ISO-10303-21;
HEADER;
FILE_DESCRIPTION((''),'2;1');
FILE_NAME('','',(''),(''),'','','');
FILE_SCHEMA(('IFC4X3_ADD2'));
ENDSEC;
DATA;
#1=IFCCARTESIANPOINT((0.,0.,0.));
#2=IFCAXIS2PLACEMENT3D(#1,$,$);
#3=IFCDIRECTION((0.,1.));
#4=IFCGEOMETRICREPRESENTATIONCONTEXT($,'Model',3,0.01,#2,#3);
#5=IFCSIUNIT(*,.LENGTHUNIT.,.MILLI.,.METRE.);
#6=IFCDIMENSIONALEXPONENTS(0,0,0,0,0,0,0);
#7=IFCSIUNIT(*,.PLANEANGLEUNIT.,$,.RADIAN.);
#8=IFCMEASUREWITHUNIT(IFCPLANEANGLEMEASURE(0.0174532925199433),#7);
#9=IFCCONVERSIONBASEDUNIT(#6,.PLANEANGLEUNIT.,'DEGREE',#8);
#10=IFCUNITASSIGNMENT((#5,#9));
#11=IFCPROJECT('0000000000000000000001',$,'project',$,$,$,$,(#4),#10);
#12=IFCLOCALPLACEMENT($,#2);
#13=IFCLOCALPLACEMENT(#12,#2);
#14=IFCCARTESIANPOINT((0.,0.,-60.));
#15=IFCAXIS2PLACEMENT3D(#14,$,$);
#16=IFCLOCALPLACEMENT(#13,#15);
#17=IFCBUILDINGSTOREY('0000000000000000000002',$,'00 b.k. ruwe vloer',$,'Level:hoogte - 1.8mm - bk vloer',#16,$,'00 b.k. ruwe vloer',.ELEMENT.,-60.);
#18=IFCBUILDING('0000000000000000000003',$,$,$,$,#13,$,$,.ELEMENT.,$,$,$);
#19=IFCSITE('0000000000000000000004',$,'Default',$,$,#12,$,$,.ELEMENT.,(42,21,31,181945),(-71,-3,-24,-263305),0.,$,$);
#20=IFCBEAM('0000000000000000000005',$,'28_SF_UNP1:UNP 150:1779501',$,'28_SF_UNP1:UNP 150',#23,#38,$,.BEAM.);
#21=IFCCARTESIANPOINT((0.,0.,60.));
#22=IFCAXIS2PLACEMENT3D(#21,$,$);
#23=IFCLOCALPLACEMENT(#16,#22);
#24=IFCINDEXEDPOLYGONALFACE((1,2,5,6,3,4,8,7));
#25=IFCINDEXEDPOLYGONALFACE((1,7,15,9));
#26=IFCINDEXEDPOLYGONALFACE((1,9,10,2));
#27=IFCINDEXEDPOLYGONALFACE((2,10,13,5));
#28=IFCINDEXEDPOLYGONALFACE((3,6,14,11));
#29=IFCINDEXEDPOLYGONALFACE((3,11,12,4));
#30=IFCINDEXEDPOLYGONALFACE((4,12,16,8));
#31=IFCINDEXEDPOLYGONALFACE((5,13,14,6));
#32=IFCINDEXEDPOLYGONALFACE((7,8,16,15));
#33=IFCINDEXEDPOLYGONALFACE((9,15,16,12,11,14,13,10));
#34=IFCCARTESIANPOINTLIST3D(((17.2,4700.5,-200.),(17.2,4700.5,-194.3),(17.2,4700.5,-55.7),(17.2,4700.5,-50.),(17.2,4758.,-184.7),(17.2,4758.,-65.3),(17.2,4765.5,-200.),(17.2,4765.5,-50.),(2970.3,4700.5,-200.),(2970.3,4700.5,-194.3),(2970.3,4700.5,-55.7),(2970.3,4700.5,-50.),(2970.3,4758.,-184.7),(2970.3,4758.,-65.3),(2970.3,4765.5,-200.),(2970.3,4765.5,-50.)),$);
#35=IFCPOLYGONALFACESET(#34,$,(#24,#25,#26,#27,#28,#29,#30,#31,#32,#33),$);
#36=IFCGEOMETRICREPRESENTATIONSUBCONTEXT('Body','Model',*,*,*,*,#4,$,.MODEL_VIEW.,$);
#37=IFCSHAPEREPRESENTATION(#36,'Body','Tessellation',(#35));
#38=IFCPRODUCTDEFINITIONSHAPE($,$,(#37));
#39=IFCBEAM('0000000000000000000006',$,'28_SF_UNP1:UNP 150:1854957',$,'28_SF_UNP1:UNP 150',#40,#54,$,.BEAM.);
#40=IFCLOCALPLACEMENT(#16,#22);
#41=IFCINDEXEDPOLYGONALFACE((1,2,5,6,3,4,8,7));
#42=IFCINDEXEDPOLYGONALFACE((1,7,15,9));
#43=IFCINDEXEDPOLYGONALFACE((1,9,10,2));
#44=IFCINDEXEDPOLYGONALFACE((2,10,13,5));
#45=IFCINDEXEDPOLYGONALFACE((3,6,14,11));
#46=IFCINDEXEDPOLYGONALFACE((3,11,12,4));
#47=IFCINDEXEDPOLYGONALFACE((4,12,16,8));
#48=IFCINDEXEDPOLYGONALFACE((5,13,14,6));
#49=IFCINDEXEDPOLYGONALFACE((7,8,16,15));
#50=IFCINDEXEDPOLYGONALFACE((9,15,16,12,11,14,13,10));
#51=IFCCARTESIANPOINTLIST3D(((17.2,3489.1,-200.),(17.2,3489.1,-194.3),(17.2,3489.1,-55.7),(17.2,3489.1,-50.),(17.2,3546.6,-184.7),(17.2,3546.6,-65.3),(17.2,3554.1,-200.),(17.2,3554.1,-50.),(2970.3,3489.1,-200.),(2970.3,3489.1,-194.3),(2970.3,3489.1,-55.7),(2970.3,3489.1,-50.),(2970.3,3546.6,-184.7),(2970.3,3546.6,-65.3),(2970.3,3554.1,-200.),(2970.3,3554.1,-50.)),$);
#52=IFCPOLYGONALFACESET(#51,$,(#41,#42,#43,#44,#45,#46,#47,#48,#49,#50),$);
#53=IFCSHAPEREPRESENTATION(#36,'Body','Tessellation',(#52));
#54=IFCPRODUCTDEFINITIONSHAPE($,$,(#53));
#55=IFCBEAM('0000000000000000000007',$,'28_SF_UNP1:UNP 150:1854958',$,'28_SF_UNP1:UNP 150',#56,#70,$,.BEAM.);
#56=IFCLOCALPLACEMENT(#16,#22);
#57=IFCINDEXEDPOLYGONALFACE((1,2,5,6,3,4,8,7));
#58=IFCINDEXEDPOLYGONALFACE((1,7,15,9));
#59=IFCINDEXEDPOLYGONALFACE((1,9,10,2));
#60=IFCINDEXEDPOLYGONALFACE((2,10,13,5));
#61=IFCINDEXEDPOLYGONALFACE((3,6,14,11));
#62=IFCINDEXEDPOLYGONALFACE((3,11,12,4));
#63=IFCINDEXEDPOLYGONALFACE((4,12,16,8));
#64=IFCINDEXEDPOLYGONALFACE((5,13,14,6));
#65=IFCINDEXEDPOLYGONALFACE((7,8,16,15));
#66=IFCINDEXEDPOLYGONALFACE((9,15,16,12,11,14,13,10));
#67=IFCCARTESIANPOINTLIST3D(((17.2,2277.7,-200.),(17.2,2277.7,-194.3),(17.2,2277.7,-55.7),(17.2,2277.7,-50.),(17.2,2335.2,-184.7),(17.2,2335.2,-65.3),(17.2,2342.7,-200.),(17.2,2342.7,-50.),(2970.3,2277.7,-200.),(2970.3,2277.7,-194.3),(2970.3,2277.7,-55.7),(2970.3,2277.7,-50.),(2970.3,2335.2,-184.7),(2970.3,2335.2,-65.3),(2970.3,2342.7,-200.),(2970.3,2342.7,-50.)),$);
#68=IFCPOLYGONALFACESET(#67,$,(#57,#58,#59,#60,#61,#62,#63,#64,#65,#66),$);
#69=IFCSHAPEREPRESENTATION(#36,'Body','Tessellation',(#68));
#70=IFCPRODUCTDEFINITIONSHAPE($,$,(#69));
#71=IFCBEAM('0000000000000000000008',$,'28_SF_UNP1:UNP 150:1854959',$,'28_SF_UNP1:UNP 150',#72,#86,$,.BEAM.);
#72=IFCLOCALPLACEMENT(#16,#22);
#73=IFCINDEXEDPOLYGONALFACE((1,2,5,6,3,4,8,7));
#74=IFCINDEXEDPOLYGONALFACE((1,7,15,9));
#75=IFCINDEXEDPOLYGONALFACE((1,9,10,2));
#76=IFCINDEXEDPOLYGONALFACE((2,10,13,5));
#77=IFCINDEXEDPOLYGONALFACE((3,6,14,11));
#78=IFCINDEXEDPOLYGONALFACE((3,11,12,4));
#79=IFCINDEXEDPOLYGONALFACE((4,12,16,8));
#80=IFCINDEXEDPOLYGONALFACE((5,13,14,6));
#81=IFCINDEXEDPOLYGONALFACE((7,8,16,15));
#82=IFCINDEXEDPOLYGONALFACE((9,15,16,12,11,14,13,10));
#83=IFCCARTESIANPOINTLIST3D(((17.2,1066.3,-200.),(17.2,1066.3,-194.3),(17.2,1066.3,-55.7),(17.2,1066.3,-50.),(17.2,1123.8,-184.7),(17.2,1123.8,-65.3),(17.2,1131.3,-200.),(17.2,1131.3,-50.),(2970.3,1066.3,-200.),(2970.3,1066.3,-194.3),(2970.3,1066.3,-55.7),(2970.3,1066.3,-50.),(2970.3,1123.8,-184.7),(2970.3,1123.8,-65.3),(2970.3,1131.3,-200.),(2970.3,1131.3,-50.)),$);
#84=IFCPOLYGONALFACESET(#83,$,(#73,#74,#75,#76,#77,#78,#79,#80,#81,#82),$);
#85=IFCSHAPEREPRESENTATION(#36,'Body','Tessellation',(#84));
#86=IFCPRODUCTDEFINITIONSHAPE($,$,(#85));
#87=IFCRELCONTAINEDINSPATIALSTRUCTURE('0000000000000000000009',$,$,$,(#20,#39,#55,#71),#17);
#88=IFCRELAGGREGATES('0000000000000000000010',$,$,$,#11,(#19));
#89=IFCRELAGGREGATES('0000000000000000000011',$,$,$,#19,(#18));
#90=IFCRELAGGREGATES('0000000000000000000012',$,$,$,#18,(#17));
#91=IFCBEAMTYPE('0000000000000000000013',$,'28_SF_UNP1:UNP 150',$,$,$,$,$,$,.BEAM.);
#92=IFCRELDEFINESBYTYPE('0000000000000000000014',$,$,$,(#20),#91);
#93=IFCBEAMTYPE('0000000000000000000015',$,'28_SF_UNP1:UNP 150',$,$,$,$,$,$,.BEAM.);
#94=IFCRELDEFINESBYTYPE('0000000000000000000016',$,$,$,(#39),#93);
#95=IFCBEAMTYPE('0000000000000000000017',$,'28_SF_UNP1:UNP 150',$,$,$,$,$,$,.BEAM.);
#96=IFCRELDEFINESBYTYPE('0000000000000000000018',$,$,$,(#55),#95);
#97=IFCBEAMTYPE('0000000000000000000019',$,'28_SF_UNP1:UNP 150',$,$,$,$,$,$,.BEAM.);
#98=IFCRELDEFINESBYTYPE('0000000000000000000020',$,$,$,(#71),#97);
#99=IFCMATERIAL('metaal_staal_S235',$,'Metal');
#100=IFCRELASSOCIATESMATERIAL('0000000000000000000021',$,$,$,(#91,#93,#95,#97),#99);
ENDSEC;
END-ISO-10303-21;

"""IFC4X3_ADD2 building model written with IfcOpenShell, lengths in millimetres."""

from ifc_helpers import new_model, entity, si_unit, converted_unit, direction, frame, origin, place, context, subcontext, project, spatial, polyline, outline, extrude, source, transform, mapped, material, material_profile, profile_set, type_object, type_shapes, element, save


model = new_model("IFC4X3_ADD2")

# Units and contexts
model_context = context("Model", 3, precision=0.01, world=origin(), true_north=direction((0.0, 1.0)))
body_context = subcontext(model_context, "Body", "Model", "MODEL_VIEW")
ifc_project = project(units=[si_unit("LENGTHUNIT", "METRE", prefix="MILLI"), converted_unit("PLANEANGLEUNIT", "DEGREE", entity("IfcPlaneAngleMeasure", 0.0174532925199433), si_unit("PLANEANGLEUNIT", "RADIAN"), dimensions=[0, 0, 0, 0, 0, 0, 0])], contexts=[model_context])

# Site, building, storey
site_placement = place(None, origin())
site = spatial("IfcSite", under=ifc_project, at=site_placement, Name="Default", CompositionType="ELEMENT", RefLatitude=(42, 21, 31, 181945), RefLongitude=(-71, -3, -24, -263305), RefElevation=0.0)
building_placement = place(site_placement, origin())
building = spatial("IfcBuilding", under=site, at=building_placement, CompositionType="ELEMENT")
storey_placement = place(building_placement, frame((0.0, 0.0, -60.0)))
storey = spatial("IfcBuildingStorey", under=building, at=storey_placement, Name="00 b.k. ruwe vloer", ObjectType="Level:hoogte - 1.8mm - bk vloer", LongName="00 b.k. ruwe vloer", CompositionType="ELEMENT", Elevation=-60.0)

# Beams
ifc_material = material(Name="metaal_staal_S235", Category="Metal")
ifc_material_profile = material_profile(ifc_material, outline(polyline([(-75.0, -30.6), (-69.3, -30.6), (-59.7, 26.9), (59.7, 26.9), (69.3, -30.6), (75.0, -30.6), (75.0, 34.4), (-75.0, 34.4), (-75.0, -30.6)])), Name="UNP 150")
ifc_profile_set = profile_set([ifc_material_profile], Name="UNP 150")
beam_type_1 = type_object("IfcBeamType", Name="28_SF_UNP1:UNP 150", PredefinedType="BEAM", material=ifc_profile_set)
shared_shape_1 = source(origin(), body_context, "Body", "SweptSolid", [
    extrude(outline(polyline([(-75.0, -30.6), (-69.3, -30.6), (-59.7, 26.9), (59.7, 26.9), (69.3, -30.6), (75.0, -30.6), (75.0, 34.4), (-75.0, 34.4), (-75.0, -30.6)])), frame((17.2, 4731.2, -125.0), z_axis=(1.0, 0.0, 0.0), x_axis=(0.0, 0.0, -1.0)), (0.0, 0.0, 1.0), 2953.2),
])
type_shapes(beam_type_1, [shared_shape_1])
beam_1_placement = place(storey_placement, frame((0.0, 0.0, 60.0)))
element("IfcBeam", 1, at=beam_1_placement, inside=storey, type_object=beam_type_1, Name="28_SF_UNP1:UNP 150:1779501", ObjectType="28_SF_UNP1:UNP 150", PredefinedType="BEAM", context=body_context, shape_type="MappedRepresentation", body=[
    mapped(shared_shape_1, transform((0.0, 0.0, 0.0), scale=1.0)),
])
beam_type_2 = type_object("IfcBeamType", Name="28_SF_UNP1:UNP 150", PredefinedType="BEAM", material=ifc_profile_set)
shared_shape_2 = source(origin(), body_context, "Body", "SweptSolid", [
    extrude(outline(polyline([(-75.0, -30.6), (-69.3, -30.6), (-59.7, 26.9), (59.7, 26.9), (69.3, -30.6), (75.0, -30.6), (75.0, 34.4), (-75.0, 34.4), (-75.0, -30.6)])), frame((17.2, 3519.8, -125.0), z_axis=(1.0, 0.0, 0.0), x_axis=(0.0, 0.0, -1.0)), (0.0, 0.0, 1.0), 2953.2),
])
type_shapes(beam_type_2, [shared_shape_2])
beam_2_placement = place(storey_placement, frame((0.0, 0.0, 60.0)))
element("IfcBeam", 2, at=beam_2_placement, inside=storey, type_object=beam_type_2, Name="28_SF_UNP1:UNP 150:1854957", ObjectType="28_SF_UNP1:UNP 150", PredefinedType="BEAM", context=body_context, shape_type="MappedRepresentation", body=[
    mapped(shared_shape_2, transform((0.0, 0.0, 0.0), scale=1.0)),
])
beam_type_3 = type_object("IfcBeamType", Name="28_SF_UNP1:UNP 150", PredefinedType="BEAM", material=ifc_profile_set)
shared_shape_3 = source(origin(), body_context, "Body", "SweptSolid", [
    extrude(outline(polyline([(-75.0, -30.6), (-69.3, -30.6), (-59.7, 26.9), (59.7, 26.9), (69.3, -30.6), (75.0, -30.6), (75.0, 34.4), (-75.0, 34.4), (-75.0, -30.6)])), frame((17.2, 2308.4, -125.0), z_axis=(1.0, 0.0, 0.0), x_axis=(0.0, 0.0, -1.0)), (0.0, 0.0, 1.0), 2953.2),
])
type_shapes(beam_type_3, [shared_shape_3])
beam_3_placement = place(storey_placement, frame((0.0, 0.0, 60.0)))
element("IfcBeam", 3, at=beam_3_placement, inside=storey, type_object=beam_type_3, Name="28_SF_UNP1:UNP 150:1854958", ObjectType="28_SF_UNP1:UNP 150", PredefinedType="BEAM", context=body_context, shape_type="MappedRepresentation", body=[
    mapped(shared_shape_3, transform((0.0, 0.0, 0.0), scale=1.0)),
])
beam_type_4 = type_object("IfcBeamType", Name="28_SF_UNP1:UNP 150", PredefinedType="BEAM", material=ifc_profile_set)
shared_shape_4 = source(origin(), body_context, "Body", "SweptSolid", [
    extrude(outline(polyline([(-75.0, -30.6), (-69.3, -30.6), (-59.7, 26.9), (59.7, 26.9), (69.3, -30.6), (75.0, -30.6), (75.0, 34.4), (-75.0, 34.4), (-75.0, -30.6)])), frame((17.2, 1097.0, -125.0), z_axis=(1.0, 0.0, 0.0), x_axis=(0.0, 0.0, -1.0)), (0.0, 0.0, 1.0), 2953.2),
])
type_shapes(beam_type_4, [shared_shape_4])
beam_4_placement = place(storey_placement, frame((0.0, 0.0, 60.0)))
element("IfcBeam", 4, at=beam_4_placement, inside=storey, type_object=beam_type_4, Name="28_SF_UNP1:UNP 150:1854959", ObjectType="28_SF_UNP1:UNP 150", PredefinedType="BEAM", context=body_context, shape_type="MappedRepresentation", body=[
    mapped(shared_shape_4, transform((0.0, 0.0, 0.0), scale=1.0)),
])

save(model, "model.ifc")
